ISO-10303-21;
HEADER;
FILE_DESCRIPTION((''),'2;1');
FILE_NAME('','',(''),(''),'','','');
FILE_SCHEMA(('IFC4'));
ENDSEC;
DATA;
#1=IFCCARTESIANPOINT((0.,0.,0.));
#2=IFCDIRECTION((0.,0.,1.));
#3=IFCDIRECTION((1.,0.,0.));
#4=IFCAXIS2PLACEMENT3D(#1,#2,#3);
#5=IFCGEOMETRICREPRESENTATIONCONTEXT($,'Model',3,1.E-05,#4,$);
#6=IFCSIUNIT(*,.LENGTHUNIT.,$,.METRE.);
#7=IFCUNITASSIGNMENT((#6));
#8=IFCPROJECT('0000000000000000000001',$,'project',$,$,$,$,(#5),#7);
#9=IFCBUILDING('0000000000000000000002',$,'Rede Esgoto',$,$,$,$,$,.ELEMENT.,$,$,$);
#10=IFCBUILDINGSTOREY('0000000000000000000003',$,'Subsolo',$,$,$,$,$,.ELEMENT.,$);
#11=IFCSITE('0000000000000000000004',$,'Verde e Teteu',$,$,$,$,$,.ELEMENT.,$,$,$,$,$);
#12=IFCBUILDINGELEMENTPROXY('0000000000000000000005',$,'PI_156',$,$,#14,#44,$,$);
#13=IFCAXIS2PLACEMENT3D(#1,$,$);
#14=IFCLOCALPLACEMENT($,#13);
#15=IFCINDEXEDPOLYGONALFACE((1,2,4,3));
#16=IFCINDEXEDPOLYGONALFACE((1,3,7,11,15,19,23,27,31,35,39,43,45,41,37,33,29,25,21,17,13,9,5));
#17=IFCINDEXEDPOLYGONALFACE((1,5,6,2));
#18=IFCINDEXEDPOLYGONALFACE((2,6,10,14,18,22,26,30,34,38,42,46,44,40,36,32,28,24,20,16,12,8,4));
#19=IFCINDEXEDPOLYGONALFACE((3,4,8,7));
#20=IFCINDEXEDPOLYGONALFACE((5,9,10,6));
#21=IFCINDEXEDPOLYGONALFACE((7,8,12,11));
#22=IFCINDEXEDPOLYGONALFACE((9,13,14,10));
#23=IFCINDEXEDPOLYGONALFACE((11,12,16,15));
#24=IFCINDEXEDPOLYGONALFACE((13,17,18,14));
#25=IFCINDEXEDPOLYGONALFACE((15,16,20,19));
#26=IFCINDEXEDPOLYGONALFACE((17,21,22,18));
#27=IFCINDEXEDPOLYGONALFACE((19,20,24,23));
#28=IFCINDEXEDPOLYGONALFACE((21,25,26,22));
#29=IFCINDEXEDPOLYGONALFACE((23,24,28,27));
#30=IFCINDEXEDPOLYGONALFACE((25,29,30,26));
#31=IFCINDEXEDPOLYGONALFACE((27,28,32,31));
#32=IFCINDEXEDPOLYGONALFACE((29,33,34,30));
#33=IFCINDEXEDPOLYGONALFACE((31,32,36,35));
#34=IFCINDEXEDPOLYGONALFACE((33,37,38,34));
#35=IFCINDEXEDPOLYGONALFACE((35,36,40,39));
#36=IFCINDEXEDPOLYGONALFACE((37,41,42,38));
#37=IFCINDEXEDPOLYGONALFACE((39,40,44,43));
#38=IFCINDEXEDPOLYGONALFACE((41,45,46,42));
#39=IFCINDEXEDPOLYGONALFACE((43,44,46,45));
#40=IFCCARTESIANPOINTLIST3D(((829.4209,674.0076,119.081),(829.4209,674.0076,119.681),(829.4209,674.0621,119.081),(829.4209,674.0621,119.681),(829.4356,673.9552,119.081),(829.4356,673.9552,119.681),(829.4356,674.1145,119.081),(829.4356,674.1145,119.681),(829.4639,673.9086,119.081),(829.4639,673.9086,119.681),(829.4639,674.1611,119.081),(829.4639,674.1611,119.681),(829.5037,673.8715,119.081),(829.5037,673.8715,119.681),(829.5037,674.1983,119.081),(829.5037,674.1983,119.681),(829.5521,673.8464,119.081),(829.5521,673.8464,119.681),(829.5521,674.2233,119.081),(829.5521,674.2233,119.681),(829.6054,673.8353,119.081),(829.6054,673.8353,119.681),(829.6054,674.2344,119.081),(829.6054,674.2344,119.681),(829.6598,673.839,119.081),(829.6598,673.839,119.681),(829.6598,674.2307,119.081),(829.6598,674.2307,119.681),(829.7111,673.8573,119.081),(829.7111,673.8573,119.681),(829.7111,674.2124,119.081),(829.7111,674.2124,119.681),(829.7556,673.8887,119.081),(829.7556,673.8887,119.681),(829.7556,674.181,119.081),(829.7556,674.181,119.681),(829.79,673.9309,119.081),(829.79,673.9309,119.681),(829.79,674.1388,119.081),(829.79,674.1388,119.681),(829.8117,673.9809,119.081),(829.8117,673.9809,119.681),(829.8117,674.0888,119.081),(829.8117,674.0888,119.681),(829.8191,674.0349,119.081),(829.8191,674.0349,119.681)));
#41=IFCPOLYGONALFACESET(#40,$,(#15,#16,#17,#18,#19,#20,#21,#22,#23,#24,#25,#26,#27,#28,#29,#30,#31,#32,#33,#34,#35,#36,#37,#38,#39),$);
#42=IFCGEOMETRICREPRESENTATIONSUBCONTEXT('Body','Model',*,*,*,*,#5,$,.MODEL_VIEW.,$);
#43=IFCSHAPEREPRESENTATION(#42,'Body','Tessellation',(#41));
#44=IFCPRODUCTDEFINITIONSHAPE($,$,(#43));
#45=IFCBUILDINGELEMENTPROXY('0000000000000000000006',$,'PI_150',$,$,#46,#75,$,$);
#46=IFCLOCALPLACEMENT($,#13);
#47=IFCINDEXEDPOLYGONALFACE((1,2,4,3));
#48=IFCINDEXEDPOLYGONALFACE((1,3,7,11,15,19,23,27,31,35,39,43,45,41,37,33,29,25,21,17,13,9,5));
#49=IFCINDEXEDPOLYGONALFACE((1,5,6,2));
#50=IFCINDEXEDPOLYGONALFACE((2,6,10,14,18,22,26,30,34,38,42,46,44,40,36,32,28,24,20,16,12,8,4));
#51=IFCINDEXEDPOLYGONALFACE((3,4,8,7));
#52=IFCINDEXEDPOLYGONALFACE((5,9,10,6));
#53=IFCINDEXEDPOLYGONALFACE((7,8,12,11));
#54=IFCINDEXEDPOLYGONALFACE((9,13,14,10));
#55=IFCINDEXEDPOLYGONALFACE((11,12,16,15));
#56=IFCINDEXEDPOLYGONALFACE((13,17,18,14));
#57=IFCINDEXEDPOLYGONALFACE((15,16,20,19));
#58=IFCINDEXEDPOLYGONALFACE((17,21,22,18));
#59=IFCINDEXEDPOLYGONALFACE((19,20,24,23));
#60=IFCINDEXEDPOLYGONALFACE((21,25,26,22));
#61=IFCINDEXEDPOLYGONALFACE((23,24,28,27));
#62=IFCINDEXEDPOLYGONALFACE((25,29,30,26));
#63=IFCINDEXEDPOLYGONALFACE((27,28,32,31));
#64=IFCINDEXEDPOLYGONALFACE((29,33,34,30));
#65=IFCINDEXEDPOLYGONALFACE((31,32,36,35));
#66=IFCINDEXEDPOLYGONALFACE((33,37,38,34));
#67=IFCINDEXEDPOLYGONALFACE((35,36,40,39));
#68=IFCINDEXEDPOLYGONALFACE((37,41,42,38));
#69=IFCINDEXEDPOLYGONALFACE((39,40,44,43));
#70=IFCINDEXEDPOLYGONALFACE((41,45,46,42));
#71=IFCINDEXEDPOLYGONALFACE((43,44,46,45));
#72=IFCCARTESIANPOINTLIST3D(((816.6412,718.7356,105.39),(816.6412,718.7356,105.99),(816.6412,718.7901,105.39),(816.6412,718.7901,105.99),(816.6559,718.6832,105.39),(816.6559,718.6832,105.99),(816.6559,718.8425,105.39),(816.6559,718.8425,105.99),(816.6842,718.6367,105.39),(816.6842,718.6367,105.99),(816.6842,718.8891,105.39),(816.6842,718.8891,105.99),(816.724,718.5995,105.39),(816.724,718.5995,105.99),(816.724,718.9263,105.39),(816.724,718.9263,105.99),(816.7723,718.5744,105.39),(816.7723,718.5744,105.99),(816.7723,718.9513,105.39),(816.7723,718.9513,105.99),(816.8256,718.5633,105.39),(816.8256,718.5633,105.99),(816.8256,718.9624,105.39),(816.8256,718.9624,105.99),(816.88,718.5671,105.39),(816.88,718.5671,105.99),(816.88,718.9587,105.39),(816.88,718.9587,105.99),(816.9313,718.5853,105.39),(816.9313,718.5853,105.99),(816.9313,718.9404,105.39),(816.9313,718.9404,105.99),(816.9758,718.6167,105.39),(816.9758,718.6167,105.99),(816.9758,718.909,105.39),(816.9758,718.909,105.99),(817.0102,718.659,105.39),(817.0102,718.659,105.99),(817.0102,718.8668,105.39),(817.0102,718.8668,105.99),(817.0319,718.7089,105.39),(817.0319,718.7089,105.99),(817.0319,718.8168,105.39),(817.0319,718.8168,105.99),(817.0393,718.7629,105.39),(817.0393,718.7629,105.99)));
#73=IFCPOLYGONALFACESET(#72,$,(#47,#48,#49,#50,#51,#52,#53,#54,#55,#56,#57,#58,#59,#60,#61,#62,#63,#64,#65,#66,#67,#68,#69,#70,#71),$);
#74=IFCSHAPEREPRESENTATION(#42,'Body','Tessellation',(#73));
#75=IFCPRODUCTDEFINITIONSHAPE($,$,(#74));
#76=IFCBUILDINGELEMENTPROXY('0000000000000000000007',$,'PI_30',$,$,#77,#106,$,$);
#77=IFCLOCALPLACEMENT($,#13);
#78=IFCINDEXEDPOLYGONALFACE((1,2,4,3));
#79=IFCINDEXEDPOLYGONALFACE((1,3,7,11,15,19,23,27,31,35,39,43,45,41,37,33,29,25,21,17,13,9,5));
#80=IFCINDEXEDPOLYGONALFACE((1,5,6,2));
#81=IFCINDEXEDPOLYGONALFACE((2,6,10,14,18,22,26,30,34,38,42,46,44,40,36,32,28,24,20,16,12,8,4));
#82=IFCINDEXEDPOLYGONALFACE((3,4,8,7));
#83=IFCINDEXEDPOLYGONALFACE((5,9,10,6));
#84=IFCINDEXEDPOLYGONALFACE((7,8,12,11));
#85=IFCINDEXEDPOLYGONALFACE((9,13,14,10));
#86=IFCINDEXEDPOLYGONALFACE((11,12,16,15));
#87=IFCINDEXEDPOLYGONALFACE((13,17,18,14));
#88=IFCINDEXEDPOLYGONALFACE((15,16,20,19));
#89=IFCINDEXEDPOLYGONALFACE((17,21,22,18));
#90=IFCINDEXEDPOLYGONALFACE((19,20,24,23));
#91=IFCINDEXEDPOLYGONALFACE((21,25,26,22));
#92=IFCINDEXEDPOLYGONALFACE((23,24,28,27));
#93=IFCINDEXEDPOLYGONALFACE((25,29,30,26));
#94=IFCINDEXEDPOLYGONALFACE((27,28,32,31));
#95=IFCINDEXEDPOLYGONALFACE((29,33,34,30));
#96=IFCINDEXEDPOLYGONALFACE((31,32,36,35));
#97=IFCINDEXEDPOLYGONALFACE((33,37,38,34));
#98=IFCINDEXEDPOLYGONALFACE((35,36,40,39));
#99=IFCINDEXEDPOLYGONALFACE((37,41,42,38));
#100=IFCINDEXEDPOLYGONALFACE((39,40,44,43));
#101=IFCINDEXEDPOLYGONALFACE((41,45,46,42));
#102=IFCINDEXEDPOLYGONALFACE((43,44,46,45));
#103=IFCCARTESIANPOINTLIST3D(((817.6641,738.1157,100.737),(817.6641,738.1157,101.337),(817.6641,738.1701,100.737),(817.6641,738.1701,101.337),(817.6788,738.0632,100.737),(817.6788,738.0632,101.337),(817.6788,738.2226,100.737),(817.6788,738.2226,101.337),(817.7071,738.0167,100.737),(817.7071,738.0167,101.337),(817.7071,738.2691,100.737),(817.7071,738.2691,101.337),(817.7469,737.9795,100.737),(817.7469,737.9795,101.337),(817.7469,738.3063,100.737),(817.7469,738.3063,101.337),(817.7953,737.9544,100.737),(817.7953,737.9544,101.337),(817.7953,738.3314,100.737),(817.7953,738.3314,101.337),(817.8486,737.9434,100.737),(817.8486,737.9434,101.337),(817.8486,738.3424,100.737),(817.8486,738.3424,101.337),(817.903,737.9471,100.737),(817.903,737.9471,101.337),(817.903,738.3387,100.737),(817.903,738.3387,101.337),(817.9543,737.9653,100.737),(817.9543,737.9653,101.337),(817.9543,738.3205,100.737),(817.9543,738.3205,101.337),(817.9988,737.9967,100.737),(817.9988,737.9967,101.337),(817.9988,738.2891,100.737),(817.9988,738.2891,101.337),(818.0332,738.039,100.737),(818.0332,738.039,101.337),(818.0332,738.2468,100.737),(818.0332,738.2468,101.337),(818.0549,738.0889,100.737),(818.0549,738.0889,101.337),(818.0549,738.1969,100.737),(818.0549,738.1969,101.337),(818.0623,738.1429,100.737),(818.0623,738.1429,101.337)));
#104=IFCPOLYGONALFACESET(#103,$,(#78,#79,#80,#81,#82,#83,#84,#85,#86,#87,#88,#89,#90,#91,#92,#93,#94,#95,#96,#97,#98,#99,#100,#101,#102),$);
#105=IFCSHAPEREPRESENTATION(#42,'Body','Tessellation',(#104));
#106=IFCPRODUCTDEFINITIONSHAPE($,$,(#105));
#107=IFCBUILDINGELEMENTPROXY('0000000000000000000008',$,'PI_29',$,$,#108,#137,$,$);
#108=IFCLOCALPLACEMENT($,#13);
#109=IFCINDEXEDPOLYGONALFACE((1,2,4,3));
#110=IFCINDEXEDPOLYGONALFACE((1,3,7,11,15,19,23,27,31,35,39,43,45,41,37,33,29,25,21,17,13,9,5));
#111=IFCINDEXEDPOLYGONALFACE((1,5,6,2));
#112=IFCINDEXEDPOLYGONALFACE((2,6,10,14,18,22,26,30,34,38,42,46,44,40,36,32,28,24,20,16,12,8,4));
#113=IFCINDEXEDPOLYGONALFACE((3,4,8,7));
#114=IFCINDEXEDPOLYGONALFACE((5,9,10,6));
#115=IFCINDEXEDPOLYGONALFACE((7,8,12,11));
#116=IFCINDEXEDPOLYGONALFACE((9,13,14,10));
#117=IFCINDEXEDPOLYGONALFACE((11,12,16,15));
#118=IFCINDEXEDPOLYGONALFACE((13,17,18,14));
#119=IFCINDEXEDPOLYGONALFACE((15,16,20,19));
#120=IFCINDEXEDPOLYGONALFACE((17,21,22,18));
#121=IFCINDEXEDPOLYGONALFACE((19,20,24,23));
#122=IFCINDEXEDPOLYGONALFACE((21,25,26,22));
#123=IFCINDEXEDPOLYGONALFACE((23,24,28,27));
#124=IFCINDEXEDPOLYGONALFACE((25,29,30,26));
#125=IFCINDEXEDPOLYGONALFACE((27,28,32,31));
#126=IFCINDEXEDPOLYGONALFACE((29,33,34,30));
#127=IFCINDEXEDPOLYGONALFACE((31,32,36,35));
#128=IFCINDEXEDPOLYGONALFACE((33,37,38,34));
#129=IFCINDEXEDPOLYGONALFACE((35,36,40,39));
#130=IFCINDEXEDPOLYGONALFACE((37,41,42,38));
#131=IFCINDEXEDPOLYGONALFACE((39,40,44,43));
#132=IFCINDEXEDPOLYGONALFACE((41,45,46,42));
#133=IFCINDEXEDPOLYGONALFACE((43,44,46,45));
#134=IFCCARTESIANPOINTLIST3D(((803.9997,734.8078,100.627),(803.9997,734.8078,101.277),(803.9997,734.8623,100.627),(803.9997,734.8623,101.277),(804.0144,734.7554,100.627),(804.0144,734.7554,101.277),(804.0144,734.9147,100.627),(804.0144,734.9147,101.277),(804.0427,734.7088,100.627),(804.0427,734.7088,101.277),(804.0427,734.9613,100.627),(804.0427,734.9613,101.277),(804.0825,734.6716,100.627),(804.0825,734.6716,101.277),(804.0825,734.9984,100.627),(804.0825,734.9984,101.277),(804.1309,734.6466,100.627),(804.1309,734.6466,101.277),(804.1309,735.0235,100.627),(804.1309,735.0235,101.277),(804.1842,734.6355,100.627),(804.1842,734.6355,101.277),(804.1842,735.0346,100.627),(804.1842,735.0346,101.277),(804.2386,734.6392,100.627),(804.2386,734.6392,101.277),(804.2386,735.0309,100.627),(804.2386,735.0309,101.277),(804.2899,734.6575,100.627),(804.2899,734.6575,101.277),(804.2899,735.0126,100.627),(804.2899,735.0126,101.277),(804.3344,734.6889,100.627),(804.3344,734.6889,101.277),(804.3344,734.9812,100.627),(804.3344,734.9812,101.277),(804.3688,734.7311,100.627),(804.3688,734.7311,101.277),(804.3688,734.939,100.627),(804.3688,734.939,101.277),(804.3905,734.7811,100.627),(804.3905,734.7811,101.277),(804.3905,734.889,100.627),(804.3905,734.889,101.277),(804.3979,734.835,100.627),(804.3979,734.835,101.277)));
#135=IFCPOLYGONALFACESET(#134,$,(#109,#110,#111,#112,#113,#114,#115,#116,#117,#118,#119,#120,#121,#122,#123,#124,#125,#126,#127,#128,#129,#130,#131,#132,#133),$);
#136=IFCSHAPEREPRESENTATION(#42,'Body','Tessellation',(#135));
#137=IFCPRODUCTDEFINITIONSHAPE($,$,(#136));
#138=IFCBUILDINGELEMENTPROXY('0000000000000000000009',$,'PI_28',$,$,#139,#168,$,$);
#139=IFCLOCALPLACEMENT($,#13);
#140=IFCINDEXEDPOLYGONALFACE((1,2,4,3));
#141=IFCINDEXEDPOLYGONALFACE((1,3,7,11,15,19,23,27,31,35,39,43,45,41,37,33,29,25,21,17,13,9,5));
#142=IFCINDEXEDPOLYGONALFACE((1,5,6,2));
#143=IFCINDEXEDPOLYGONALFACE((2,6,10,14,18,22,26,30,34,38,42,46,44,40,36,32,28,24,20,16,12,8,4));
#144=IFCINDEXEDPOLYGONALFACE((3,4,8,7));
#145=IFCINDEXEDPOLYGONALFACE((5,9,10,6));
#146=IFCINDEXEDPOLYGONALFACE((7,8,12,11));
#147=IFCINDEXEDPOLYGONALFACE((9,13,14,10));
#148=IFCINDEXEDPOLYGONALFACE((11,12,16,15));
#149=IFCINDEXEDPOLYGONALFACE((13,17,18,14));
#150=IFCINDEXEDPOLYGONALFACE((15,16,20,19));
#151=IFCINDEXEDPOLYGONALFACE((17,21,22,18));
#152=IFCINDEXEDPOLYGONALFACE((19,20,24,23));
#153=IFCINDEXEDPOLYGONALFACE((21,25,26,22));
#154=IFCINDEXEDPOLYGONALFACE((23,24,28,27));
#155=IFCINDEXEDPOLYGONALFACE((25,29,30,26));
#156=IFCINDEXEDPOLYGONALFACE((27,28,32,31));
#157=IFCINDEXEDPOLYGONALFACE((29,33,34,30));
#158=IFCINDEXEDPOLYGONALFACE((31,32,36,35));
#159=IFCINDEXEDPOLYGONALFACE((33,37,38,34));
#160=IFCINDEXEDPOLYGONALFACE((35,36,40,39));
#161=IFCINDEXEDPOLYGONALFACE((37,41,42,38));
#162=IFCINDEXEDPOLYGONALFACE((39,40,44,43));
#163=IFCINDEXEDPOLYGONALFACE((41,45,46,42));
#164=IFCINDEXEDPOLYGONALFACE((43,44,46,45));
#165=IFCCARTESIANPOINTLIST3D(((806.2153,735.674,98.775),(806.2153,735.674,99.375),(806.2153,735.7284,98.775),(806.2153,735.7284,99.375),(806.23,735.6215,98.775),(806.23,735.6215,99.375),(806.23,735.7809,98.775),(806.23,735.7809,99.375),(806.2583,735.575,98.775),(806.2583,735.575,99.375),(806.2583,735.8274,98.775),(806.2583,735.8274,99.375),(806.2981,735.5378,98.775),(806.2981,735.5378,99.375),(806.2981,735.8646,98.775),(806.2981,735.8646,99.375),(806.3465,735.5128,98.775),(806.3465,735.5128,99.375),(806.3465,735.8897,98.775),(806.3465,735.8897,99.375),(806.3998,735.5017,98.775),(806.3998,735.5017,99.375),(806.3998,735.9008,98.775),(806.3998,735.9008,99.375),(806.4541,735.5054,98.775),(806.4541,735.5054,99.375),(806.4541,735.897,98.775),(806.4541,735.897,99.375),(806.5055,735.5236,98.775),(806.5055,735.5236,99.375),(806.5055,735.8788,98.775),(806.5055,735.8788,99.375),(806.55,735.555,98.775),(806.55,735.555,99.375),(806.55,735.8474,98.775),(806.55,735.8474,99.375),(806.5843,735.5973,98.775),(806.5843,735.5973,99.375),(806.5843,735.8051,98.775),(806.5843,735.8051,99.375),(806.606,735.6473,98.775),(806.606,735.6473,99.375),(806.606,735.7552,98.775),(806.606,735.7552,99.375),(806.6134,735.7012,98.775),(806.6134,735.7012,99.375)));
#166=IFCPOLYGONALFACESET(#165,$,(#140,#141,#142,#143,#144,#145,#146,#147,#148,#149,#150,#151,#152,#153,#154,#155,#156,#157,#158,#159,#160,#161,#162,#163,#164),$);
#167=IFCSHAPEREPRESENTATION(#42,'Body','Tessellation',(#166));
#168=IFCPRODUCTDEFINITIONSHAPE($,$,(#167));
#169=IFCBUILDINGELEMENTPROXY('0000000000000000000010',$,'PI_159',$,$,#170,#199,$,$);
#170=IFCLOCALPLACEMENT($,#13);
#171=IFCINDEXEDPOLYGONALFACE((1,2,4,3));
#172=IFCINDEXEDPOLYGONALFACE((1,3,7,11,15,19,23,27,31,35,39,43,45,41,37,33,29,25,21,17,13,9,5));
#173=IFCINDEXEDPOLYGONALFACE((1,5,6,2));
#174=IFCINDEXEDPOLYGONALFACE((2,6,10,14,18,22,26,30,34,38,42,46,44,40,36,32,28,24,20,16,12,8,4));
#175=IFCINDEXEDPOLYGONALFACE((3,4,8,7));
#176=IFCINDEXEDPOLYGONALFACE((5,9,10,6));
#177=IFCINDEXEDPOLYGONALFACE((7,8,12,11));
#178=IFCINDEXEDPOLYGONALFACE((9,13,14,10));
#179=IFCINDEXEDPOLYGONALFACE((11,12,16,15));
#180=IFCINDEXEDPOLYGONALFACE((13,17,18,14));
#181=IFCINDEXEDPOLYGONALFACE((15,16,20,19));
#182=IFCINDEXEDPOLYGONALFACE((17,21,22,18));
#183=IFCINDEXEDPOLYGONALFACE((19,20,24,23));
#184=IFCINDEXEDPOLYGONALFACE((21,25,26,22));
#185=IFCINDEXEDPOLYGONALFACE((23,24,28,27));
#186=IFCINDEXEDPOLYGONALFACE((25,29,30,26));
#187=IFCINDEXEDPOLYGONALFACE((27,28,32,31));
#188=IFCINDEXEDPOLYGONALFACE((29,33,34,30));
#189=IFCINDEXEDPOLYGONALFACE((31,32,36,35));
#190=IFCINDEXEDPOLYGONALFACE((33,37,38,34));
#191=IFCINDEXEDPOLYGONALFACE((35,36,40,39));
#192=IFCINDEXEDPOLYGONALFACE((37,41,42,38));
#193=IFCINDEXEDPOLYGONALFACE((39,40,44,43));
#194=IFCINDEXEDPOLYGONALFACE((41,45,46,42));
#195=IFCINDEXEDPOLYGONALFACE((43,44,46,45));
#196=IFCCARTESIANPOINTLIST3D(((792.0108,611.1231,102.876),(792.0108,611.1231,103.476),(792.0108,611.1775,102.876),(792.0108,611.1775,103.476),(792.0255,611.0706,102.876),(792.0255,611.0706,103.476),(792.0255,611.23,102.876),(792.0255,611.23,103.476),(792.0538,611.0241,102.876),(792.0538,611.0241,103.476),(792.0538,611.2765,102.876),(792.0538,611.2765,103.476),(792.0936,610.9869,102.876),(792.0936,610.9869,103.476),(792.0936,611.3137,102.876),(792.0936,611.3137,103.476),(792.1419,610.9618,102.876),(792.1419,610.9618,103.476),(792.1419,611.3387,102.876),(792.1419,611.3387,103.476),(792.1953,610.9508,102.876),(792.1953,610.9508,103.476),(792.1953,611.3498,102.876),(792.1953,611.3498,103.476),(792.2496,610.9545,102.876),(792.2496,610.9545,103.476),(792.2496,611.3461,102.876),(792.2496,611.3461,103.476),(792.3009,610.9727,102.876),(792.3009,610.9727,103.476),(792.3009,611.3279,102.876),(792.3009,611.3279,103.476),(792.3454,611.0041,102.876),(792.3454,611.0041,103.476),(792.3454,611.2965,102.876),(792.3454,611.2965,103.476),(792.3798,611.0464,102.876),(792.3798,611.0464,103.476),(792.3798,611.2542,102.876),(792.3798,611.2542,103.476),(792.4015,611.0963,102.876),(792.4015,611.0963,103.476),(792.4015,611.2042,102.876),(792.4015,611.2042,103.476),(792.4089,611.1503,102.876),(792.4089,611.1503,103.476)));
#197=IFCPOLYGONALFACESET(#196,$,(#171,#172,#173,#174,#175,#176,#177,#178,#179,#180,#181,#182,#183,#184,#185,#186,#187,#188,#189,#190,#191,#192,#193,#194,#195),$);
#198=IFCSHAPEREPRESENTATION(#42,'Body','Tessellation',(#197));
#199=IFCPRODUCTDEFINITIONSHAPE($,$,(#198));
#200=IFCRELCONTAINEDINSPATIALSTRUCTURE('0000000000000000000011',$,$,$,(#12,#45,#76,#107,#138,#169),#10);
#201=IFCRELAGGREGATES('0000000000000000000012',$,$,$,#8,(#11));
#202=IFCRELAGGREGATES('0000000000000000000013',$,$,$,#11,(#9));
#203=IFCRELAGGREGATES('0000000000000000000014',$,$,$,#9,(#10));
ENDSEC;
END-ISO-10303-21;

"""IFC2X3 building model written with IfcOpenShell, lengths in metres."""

from ifc_helpers import new_model, si_unit, frame, origin_with_axes, origin_2d, place, context, subcontext, project, spatial, circle, extrude, element, save


model = new_model("IFC2X3")

# Units and contexts
model_context = context("Model", 3, precision=1e-05, world=origin_with_axes())
body_context = subcontext(model_context, "Body", "Model", "MODEL_VIEW")
ifc_project = project(units=[si_unit("LENGTHUNIT", "METRE")], contexts=[model_context])

# Site, building, storey
site = spatial("IfcSite", under=ifc_project, Name="Verde e Teteu", CompositionType="ELEMENT")
building = spatial("IfcBuilding", under=site, Name="Rede Esgoto", CompositionType="ELEMENT")
storey = spatial("IfcBuildingStorey", under=building, Name="Subsolo", CompositionType="ELEMENT")

# Building element proxies
for number, where, z_axis, x_axis, name in (
    (1, (829.6191, 674.0349, 119.081), (0.0, 0.0, 1.0), (1.0, 0.0, 0.0), "PI_156"),
    (2, (816.8393, 718.7629, 105.39), (0.0, 0.0, 1.0), (1.0, 0.0, 0.0), "PI_150"),
):
    element("IfcBuildingElementProxy", number, at=place(None, frame(where, z_axis=z_axis, x_axis=x_axis)), inside=storey, Name=name, context=body_context, shape_type="SweptSolid", body=[
        extrude(circle(Radius=0.2, at=origin_2d()), origin_with_axes(), (0.0, 0.0, 1.0), 0.6),
    ])
proxy_1_placement = place(None, frame((817.8623, 738.1429, 100.737), z_axis=(0.0, 0.0, 1.0), x_axis=(1.0, 0.0, 0.0)))
element("IfcBuildingElementProxy", 3, at=proxy_1_placement, inside=storey, Name="PI_30", context=body_context, shape_type="SweptSolid", body=[
    extrude(circle(Radius=0.2, at=origin_2d()), origin_with_axes(), (0.0, 0.0, 1.0), 0.6),
])
proxy_2_placement = place(None, frame((804.1979, 734.835, 100.627), z_axis=(0.0, 0.0, 1.0), x_axis=(1.0, 0.0, 0.0)))
element("IfcBuildingElementProxy", 4, at=proxy_2_placement, inside=storey, Name="PI_29", context=body_context, shape_type="SweptSolid", body=[
    extrude(circle(Radius=0.2, at=origin_2d()), origin_with_axes(), (0.0, 0.0, 1.0), 0.65),
])
for number, where, z_axis, x_axis, name in (
    (5, (806.4134, 735.7012, 98.775), (0.0, 0.0, 1.0), (1.0, 0.0, 0.0), "PI_28"),
    (6, (792.2089, 611.1503, 102.876), (0.0, 0.0, 1.0), (1.0, 0.0, 0.0), "PI_159"),
):
    element("IfcBuildingElementProxy", number, at=place(None, frame(where, z_axis=z_axis, x_axis=x_axis)), inside=storey, Name=name, context=body_context, shape_type="SweptSolid", body=[
        extrude(circle(Radius=0.2, at=origin_2d()), origin_with_axes(), (0.0, 0.0, 1.0), 0.6),
    ])

save(model, "model.ifc")
